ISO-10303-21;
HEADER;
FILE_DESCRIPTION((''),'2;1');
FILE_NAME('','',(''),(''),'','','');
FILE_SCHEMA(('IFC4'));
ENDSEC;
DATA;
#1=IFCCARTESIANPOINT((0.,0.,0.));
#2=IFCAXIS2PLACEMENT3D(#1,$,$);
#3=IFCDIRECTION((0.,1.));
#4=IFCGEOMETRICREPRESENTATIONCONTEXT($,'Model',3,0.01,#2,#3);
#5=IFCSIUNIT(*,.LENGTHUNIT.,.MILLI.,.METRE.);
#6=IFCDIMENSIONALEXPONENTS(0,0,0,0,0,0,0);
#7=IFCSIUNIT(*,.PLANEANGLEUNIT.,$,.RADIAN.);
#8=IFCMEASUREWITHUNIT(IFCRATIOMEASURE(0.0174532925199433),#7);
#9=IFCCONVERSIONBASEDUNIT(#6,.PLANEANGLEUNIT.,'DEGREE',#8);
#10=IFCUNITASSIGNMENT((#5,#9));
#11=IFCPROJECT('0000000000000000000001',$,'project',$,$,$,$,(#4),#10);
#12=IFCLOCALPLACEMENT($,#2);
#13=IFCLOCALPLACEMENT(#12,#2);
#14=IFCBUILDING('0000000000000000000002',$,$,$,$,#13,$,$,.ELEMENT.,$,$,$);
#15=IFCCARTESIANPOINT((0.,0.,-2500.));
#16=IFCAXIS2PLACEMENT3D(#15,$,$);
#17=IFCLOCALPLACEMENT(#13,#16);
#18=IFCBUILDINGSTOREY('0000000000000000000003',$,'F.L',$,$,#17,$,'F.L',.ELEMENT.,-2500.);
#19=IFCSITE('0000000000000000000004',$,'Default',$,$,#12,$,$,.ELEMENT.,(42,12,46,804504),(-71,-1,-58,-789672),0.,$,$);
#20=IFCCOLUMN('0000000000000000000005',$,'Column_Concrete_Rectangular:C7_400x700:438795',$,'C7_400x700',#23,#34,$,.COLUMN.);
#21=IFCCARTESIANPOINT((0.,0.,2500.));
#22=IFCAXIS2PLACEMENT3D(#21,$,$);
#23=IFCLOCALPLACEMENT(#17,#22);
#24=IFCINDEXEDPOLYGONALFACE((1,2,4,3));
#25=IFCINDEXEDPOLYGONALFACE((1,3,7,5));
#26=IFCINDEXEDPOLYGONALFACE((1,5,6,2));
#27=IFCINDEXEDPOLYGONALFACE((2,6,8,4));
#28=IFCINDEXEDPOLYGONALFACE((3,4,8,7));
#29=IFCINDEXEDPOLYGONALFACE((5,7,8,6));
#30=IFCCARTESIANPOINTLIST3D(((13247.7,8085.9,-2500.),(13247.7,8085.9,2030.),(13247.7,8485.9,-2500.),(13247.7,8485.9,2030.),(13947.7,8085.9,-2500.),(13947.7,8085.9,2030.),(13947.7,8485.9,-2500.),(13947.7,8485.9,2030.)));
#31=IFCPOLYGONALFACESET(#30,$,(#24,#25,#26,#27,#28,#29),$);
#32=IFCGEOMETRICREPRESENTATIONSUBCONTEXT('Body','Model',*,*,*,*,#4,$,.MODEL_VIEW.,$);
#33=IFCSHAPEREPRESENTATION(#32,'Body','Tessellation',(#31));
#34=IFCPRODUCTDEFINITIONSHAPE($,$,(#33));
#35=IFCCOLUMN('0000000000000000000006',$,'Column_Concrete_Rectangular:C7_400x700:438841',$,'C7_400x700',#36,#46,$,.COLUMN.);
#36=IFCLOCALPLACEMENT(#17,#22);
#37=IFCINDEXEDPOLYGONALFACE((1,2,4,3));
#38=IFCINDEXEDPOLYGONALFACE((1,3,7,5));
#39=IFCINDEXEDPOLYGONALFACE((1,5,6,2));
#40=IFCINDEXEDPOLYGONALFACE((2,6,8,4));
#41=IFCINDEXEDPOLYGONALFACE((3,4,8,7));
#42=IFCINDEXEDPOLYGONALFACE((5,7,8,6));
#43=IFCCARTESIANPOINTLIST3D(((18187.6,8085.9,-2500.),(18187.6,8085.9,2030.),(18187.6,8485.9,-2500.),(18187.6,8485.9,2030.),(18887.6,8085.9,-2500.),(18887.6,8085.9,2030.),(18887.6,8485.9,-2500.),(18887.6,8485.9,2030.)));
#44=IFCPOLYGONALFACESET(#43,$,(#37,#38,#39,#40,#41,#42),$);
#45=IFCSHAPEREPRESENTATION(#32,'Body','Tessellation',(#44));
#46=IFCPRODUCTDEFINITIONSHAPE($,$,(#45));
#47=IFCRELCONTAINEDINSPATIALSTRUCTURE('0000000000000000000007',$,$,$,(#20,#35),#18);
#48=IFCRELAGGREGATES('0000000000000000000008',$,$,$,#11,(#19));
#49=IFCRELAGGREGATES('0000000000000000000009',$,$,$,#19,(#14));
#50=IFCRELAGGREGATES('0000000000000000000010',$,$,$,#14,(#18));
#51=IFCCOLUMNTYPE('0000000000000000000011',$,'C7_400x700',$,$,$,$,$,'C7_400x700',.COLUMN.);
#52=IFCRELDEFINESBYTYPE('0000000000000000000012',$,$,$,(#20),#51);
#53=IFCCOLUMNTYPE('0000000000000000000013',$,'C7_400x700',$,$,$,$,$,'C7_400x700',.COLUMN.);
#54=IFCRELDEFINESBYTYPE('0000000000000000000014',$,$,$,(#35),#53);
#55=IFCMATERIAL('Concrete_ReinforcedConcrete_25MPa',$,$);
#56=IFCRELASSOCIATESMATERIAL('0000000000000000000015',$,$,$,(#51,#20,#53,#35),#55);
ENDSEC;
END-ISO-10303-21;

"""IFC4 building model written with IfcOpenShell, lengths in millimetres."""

from ifc_helpers import new_model, entity, si_unit, converted_unit, direction, frame, frame_2d, origin, origin_2d_with_axis, place, context, subcontext, project, spatial, rectangle, extrude, source, transform, mapped, material, type_object, type_shapes, element, save


model = new_model("IFC4")

# Units and contexts
model_context = context("Model", 3, precision=0.01, world=origin(), true_north=direction((0.0, 1.0)))
body_context = subcontext(model_context, "Body", "Model", "MODEL_VIEW")
ifc_project = project(units=[si_unit("LENGTHUNIT", "METRE", prefix="MILLI"), converted_unit("PLANEANGLEUNIT", "DEGREE", entity("IfcRatioMeasure", 0.0174532925199433), si_unit("PLANEANGLEUNIT", "RADIAN"), dimensions=[0, 0, 0, 0, 0, 0, 0])], contexts=[model_context])

# Site, building, storey
site_placement = place(None, origin())
site = spatial("IfcSite", under=ifc_project, at=site_placement, Name="Default", CompositionType="ELEMENT", RefLatitude=(42, 12, 46, 804504), RefLongitude=(-71, -1, -58, -789672), RefElevation=0.0)
building_placement = place(site_placement, origin())
building = spatial("IfcBuilding", under=site, at=building_placement, CompositionType="ELEMENT")
storey_placement = place(building_placement, frame((0.0, 0.0, -2500.0)))
storey = spatial("IfcBuildingStorey", under=building, at=storey_placement, Name="F.L", LongName="F.L", CompositionType="ELEMENT", Elevation=-2500.0)

# Columns
ifc_material_1 = material(Name="Concrete_ReinforcedConcrete_25MPa")
column_type_1 = type_object("IfcColumnType", Name="C7_400x700", ElementType="C7_400x700", PredefinedType="COLUMN", material=ifc_material_1)
shared_shape_1 = source(origin(), body_context, "Body", "SweptSolid", [
    extrude(rectangle(XDim=400.0, YDim=700.0, at=frame_2d((0.0, 0.0), x_axis=(1.0, 0.0))), frame((13597.7, 8285.9, -2500.0), z_axis=(0.0, 0.0, 1.0), x_axis=(0.0, -1.0, 0.0)), (0.0, 0.0, 1.0), 4530.0),
])
type_shapes(column_type_1, [shared_shape_1])
column_1_placement = place(storey_placement, frame((0.0, 0.0, 2500.0)))
element("IfcColumn", 1, at=column_1_placement, inside=storey, type_object=column_type_1, material=ifc_material_1, Name="Column_Concrete_Rectangular:C7_400x700:438795", ObjectType="C7_400x700", PredefinedType="COLUMN", context=body_context, shape_type="MappedRepresentation", body=[
    mapped(shared_shape_1, transform((0.0, 0.0, 0.0), scale=1.0)),
])
column_type_2 = type_object("IfcColumnType", Name="C7_400x700", ElementType="C7_400x700", PredefinedType="COLUMN", material=ifc_material_1)
shared_shape_2 = source(origin(), body_context, "Body", "SweptSolid", [
    extrude(rectangle(XDim=400.0, YDim=700.0, at=origin_2d_with_axis()), frame((18537.6, 8285.9, -2500.0), z_axis=(0.0, 0.0, 1.0), x_axis=(0.0, -1.0, 0.0)), (0.0, 0.0, 1.0), 4530.0),
])
type_shapes(column_type_2, [shared_shape_2])
column_2_placement = place(storey_placement, frame((0.0, 0.0, 2500.0)))
element("IfcColumn", 2, at=column_2_placement, inside=storey, type_object=column_type_2, material=ifc_material_1, Name="Column_Concrete_Rectangular:C7_400x700:438841", ObjectType="C7_400x700", PredefinedType="COLUMN", context=body_context, shape_type="MappedRepresentation", body=[
    mapped(shared_shape_2, transform((0.0, 0.0, 0.0), scale=1.0)),
])

save(model, "model.ifc")
